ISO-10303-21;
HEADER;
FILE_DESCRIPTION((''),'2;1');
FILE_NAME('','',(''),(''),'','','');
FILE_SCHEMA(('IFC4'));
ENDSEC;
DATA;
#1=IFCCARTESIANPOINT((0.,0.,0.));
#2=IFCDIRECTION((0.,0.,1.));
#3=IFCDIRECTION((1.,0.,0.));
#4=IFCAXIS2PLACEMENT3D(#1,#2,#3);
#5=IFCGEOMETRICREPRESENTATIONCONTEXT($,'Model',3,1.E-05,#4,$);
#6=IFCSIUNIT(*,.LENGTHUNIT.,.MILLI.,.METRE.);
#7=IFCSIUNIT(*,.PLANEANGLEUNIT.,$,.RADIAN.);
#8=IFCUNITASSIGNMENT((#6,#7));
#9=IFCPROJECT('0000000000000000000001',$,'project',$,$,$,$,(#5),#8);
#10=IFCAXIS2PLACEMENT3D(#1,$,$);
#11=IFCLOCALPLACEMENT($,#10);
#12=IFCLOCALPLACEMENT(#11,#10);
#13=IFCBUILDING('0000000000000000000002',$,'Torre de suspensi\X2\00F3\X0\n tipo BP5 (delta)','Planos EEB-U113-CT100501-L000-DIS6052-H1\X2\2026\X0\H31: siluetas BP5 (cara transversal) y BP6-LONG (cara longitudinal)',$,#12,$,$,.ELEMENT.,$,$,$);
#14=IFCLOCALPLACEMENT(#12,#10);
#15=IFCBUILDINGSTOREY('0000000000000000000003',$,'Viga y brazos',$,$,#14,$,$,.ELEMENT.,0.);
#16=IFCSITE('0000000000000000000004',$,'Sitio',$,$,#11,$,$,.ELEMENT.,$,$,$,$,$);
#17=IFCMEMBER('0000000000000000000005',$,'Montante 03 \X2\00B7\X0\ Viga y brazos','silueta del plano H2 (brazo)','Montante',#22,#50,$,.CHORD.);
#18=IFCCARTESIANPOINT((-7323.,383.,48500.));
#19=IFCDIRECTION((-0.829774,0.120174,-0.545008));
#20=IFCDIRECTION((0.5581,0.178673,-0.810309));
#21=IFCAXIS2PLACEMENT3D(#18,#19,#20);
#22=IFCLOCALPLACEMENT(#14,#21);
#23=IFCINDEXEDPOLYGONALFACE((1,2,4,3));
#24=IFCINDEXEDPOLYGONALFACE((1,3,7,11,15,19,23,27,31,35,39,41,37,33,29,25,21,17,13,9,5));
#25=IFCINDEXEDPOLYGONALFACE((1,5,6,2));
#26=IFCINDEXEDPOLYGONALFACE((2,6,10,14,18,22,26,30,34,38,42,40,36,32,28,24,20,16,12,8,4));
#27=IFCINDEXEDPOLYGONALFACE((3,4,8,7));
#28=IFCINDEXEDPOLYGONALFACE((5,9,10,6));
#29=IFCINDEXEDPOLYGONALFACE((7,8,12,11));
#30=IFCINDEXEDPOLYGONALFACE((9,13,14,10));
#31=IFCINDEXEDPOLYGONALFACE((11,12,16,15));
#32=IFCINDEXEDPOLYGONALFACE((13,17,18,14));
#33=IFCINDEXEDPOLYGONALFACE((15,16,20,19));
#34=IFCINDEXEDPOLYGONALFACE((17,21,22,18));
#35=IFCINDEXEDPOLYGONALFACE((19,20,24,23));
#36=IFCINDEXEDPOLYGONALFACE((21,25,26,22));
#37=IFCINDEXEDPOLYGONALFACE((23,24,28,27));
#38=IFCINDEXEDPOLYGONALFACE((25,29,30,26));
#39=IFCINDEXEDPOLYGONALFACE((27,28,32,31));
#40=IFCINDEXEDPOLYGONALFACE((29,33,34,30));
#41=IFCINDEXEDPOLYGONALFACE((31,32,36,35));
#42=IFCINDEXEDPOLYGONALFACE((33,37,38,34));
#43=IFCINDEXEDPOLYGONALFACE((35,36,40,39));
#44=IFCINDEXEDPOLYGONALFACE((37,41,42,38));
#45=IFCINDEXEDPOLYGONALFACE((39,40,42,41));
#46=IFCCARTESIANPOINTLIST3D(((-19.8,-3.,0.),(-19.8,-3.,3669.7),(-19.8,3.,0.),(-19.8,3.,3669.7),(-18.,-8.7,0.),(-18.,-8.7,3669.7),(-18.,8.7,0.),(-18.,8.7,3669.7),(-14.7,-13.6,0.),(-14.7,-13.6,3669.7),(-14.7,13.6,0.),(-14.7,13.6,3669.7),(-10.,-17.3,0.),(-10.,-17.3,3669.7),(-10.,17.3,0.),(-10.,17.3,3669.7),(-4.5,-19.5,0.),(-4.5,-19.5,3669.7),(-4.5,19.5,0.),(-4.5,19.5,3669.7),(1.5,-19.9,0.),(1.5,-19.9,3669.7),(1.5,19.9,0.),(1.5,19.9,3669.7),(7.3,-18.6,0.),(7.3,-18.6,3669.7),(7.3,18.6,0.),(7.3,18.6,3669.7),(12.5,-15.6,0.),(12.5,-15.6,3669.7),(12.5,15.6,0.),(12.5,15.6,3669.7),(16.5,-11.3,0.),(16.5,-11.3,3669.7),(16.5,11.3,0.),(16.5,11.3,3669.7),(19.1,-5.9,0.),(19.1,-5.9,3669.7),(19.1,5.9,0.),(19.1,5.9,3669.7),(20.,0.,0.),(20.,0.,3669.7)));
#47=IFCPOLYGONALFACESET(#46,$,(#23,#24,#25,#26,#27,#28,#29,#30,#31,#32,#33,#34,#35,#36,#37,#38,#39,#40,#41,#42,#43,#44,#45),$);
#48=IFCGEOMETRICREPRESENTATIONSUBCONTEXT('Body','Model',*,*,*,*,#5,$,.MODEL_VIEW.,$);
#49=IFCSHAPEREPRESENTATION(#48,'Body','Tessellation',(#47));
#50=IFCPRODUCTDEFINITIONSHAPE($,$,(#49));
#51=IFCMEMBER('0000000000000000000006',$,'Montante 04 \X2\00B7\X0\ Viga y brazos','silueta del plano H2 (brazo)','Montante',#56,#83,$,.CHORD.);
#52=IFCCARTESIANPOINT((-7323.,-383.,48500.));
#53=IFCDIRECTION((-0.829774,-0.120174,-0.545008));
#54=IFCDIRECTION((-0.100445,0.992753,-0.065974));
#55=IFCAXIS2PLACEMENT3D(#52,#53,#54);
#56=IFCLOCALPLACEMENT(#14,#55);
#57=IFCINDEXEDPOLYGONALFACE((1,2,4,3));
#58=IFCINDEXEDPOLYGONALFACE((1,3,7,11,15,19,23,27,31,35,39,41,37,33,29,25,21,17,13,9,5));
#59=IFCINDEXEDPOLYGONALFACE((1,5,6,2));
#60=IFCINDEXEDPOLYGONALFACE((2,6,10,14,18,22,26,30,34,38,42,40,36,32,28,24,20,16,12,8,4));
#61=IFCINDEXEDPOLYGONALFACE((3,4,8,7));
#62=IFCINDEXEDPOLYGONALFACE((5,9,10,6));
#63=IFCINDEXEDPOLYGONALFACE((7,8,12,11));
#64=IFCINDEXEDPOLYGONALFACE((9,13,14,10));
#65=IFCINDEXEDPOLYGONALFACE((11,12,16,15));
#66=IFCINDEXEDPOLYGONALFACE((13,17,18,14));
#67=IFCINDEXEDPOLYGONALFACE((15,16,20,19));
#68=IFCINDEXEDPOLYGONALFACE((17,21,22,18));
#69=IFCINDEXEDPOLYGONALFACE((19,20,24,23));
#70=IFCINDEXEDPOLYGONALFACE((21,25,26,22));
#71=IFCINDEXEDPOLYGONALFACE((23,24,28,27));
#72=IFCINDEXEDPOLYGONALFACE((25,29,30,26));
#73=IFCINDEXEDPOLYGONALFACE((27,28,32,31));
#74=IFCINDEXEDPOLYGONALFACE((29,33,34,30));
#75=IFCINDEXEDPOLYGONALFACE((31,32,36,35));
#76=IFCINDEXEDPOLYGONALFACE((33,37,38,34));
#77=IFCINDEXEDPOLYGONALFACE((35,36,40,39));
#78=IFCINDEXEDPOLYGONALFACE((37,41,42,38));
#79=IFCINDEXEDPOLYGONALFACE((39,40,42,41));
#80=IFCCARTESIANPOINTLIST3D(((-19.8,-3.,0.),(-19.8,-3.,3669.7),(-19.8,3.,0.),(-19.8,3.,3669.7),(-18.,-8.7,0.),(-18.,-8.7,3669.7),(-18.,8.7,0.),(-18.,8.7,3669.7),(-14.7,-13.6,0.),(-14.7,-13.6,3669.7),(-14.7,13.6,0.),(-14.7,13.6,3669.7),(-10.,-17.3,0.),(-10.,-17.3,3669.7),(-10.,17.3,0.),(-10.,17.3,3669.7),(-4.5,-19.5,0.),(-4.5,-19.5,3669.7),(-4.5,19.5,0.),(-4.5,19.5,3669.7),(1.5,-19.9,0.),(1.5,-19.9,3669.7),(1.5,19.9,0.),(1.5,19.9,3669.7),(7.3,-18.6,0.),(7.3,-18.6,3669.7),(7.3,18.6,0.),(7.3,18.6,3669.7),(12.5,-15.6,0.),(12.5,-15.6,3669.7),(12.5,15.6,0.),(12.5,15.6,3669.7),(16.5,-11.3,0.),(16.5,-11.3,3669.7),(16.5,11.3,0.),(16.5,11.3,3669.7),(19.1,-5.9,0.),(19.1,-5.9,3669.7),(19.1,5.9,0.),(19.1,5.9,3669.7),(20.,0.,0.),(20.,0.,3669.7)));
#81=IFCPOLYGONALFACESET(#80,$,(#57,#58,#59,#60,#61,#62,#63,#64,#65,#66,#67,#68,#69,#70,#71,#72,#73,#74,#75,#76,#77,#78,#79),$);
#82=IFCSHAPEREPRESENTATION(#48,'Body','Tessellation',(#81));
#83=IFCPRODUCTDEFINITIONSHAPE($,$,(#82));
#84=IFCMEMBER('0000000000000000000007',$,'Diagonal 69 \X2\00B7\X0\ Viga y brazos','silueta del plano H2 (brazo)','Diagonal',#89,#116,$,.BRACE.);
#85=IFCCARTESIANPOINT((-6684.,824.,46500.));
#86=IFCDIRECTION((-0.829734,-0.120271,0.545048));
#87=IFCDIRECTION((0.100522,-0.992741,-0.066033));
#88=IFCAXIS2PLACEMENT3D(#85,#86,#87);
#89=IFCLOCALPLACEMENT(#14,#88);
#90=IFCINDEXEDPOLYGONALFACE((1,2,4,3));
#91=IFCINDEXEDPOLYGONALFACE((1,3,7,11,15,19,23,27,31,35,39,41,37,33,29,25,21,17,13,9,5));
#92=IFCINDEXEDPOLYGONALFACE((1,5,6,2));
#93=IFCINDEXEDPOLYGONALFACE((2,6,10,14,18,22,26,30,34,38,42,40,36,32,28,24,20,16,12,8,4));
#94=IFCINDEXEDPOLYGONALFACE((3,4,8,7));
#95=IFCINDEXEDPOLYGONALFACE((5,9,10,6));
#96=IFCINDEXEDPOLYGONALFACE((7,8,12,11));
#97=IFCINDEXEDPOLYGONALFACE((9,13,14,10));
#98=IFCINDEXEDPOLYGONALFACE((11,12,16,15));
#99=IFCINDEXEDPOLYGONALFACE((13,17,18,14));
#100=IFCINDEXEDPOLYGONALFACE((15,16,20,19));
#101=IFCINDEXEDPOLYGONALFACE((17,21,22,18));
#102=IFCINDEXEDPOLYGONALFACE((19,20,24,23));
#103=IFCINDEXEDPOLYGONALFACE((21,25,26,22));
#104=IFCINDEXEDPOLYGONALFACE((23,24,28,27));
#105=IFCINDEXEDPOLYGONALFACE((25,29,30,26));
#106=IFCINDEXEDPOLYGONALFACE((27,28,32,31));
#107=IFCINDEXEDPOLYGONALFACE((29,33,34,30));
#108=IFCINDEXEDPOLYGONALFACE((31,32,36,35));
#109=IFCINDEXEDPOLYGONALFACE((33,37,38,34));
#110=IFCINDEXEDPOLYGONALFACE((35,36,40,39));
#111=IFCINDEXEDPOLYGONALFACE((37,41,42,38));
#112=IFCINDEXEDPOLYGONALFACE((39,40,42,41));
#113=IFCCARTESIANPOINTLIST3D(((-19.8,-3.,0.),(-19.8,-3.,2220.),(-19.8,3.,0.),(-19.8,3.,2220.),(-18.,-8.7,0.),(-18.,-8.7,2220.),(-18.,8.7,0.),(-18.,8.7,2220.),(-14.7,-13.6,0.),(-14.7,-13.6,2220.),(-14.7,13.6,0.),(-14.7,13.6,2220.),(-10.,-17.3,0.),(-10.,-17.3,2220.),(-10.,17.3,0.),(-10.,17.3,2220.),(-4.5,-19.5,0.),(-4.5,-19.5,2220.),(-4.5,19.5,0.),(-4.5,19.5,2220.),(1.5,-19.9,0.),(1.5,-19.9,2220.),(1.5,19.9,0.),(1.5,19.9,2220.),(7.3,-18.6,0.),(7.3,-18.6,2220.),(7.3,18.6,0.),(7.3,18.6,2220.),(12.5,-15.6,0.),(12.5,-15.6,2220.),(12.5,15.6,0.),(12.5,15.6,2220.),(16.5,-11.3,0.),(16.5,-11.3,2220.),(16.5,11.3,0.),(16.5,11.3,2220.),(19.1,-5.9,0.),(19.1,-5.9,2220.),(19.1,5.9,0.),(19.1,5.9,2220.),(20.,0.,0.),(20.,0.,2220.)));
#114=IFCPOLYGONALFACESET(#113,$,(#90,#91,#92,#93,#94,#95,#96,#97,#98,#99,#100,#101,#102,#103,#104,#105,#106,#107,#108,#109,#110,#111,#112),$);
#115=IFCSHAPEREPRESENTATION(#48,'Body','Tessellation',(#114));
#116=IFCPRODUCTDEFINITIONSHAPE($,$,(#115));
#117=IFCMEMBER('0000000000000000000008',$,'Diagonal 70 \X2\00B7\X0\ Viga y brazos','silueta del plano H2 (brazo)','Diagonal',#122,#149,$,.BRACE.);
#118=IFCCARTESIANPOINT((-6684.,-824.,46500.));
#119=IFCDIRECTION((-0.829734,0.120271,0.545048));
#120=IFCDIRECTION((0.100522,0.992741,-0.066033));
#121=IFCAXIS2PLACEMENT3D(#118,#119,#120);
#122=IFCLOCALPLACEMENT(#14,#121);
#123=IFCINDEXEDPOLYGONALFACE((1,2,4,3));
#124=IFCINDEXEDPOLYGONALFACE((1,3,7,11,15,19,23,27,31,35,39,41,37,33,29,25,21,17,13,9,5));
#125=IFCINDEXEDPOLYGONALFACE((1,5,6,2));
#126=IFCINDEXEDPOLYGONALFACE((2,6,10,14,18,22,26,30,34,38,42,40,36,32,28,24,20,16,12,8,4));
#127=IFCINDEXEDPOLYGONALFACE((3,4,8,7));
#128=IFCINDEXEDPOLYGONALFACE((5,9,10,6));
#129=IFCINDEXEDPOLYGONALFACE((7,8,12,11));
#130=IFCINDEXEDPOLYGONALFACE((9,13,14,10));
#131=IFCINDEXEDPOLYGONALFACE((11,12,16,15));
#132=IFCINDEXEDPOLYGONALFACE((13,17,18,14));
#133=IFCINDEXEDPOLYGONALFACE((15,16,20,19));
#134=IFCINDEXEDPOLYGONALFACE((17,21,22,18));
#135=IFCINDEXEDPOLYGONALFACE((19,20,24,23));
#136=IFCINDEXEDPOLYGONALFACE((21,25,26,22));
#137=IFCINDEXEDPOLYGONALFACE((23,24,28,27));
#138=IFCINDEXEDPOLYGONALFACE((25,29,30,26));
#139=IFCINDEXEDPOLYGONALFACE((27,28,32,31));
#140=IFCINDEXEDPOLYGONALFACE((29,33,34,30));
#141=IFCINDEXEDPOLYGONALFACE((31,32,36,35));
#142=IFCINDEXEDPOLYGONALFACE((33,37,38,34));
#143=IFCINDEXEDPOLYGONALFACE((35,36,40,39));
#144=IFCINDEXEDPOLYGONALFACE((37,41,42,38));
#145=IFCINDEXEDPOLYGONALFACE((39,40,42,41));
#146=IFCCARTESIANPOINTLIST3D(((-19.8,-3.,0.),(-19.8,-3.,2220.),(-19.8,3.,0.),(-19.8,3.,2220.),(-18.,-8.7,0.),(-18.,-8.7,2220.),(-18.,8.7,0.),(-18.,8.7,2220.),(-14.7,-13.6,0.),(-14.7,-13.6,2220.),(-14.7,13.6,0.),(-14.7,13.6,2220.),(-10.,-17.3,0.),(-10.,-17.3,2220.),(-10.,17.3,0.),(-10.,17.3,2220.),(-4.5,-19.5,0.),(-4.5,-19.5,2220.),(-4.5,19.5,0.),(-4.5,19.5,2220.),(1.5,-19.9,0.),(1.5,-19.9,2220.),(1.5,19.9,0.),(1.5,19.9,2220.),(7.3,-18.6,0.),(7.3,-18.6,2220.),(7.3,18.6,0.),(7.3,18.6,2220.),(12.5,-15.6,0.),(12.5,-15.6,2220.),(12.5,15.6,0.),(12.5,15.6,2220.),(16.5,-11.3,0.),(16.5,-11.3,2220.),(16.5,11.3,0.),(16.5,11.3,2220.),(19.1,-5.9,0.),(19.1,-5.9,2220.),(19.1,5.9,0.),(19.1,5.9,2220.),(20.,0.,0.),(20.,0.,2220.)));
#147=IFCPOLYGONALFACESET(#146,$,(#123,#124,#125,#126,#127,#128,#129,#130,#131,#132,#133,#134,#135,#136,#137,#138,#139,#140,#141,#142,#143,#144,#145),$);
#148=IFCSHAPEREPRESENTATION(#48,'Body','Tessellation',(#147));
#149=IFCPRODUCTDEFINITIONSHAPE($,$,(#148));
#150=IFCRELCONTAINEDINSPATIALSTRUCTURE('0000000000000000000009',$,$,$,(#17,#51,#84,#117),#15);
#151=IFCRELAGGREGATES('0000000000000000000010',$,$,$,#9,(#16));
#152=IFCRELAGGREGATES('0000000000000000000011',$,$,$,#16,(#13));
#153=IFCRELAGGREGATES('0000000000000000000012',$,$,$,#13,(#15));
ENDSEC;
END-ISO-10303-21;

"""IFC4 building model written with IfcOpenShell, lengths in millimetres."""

from ifc_helpers import new_model, si_unit, frame, origin, origin_with_axes, place, context, subcontext, project, spatial, circle, extrude, element, save


model = new_model("IFC4")

# Units and contexts
model_context = context("Model", 3, precision=1e-05, world=origin_with_axes())
body_context = subcontext(model_context, "Body", "Model", "MODEL_VIEW")
ifc_project = project(units=[si_unit("LENGTHUNIT", "METRE", prefix="MILLI"), si_unit("PLANEANGLEUNIT", "RADIAN")], contexts=[model_context])

# Site, building, storey
site_placement = place(None, origin())
site = spatial("IfcSite", under=ifc_project, at=site_placement, Name="Sitio", CompositionType="ELEMENT")
building_placement = place(site_placement, origin())
building = spatial("IfcBuilding", under=site, at=building_placement, Name="Torre de suspensión tipo BP5 (delta)", Description="Planos EEB-U113-CT100501-L000-DIS6052-H1…H31: siluetas BP5 (cara transversal) y BP6-LONG (cara longitudinal)", CompositionType="ELEMENT")
storey_placement = place(building_placement, origin())
storey = spatial("IfcBuildingStorey", under=building, at=storey_placement, Name="Viga y brazos", CompositionType="ELEMENT", Elevation=0.0)

# Members
for number, where, z_axis, x_axis, name in (
    (1, (-7323.0, 383.0, 48500.0), (-0.829774, 0.120174, -0.545008), (0.5581, 0.178673, -0.810309), "Montante 03 · Viga y brazos"),
    (2, (-7323.0, -383.0, 48500.0), (-0.829774, -0.120174, -0.545008), (-0.100445, 0.992753, -0.065974), "Montante 04 · Viga y brazos"),
):
    element("IfcMember", number, at=place(storey_placement, frame(where, z_axis=z_axis, x_axis=x_axis)), inside=storey, Name=name, Description="silueta del plano H2 (brazo)", ObjectType="Montante", PredefinedType="CHORD", context=body_context, shape_type="SweptSolid", body=[
        extrude(circle(Radius=20.0), None, (0.0, 0.0, 1.0), 3669.7),
    ])
for number, where, z_axis, x_axis, name in (
    (3, (-6684.0, 824.0, 46500.0), (-0.829734, -0.120271, 0.545048), (0.100522, -0.992741, -0.066033), "Diagonal 69 · Viga y brazos"),
    (4, (-6684.0, -824.0, 46500.0), (-0.829734, 0.120271, 0.545048), (0.100522, 0.992741, -0.066033), "Diagonal 70 · Viga y brazos"),
):
    element("IfcMember", number, at=place(storey_placement, frame(where, z_axis=z_axis, x_axis=x_axis)), inside=storey, Name=name, Description="silueta del plano H2 (brazo)", ObjectType="Diagonal", PredefinedType="BRACE", context=body_context, shape_type="SweptSolid", body=[
        extrude(circle(Radius=20.0), None, (0.0, 0.0, 1.0), 2220.0),
    ])

save(model, "model.ifc")
